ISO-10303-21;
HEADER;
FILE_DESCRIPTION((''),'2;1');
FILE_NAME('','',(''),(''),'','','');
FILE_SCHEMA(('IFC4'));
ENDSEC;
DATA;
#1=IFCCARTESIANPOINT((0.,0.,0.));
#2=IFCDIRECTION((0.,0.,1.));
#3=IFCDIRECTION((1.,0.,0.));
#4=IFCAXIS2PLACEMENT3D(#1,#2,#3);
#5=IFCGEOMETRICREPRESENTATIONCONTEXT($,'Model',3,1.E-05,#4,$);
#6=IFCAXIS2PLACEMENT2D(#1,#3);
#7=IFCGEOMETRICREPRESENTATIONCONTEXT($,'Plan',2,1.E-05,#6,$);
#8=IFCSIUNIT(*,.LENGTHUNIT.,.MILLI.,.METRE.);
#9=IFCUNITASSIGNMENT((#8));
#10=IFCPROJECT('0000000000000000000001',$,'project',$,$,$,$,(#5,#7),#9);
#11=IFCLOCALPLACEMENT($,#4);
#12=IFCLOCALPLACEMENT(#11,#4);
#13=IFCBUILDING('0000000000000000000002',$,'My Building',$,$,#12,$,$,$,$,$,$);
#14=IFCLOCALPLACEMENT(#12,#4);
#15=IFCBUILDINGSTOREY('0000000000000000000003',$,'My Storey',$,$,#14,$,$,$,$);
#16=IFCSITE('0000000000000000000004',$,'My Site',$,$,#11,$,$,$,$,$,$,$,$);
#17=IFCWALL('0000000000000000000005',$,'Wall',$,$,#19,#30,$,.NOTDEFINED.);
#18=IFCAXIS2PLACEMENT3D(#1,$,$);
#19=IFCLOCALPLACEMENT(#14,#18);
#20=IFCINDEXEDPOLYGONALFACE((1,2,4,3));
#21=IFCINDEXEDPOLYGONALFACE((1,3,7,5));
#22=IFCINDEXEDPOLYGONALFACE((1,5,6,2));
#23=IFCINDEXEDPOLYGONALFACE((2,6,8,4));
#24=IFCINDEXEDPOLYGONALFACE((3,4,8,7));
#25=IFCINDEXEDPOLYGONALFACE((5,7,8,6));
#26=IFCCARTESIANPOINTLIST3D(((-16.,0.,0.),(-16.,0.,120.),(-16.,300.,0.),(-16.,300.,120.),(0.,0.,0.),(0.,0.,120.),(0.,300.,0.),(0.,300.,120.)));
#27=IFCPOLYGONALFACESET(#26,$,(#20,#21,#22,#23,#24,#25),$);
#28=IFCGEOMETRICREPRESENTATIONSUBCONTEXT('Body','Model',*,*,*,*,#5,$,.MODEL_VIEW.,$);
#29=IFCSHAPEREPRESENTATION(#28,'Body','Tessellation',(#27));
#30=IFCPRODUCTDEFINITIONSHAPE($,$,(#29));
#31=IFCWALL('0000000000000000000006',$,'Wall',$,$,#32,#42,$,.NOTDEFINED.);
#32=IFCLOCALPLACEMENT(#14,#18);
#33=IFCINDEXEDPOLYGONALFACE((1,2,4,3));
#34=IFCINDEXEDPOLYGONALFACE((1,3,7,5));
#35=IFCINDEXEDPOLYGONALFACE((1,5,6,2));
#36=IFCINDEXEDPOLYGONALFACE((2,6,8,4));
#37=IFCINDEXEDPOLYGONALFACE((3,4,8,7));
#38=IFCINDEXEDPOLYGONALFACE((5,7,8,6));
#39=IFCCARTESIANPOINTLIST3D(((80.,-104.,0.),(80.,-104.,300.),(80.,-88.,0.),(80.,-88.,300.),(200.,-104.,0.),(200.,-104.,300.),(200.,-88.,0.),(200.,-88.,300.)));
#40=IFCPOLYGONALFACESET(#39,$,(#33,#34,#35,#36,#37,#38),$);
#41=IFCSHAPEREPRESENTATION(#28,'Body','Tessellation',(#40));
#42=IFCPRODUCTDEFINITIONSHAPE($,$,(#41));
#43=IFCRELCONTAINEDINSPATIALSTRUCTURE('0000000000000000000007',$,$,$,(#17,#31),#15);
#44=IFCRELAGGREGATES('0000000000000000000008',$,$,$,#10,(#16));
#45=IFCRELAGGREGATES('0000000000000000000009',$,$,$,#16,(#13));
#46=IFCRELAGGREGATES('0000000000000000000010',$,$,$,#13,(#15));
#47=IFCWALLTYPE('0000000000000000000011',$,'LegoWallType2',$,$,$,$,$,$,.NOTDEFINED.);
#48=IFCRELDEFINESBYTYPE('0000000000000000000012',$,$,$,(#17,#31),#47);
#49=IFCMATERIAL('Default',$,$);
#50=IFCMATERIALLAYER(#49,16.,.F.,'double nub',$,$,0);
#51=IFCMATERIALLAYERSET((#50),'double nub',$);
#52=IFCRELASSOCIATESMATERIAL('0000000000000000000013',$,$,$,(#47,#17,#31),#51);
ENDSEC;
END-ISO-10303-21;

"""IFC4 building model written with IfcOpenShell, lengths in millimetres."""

from ifc_helpers import new_model, si_unit, frame, frame_2d, origin_with_axes, place, context, subcontext, project, spatial, indexed_curve, outline, extrude, material, layer, layer_set, layer_usage, type_object, element, save


model = new_model("IFC4")

# Units and contexts
model_context = context("Model", 3, precision=1e-05, world=origin_with_axes())
plan_context = context("Plan", 2, precision=1e-05, world=frame_2d((0.0, 0.0, 0.0), x_axis=(1.0, 0.0, 0.0)))
body_context = subcontext(model_context, "Body", "Model", "MODEL_VIEW")
ifc_project = project(units=[si_unit("LENGTHUNIT", "METRE", prefix="MILLI")], contexts=[model_context, plan_context])

# Site, building, storey
site_placement = place(None, origin_with_axes())
site = spatial("IfcSite", under=ifc_project, at=site_placement, Name="My Site")
building_placement = place(site_placement, origin_with_axes())
building = spatial("IfcBuilding", under=site, at=building_placement, Name="My Building")
storey_placement = place(building_placement, origin_with_axes())
storey = spatial("IfcBuildingStorey", under=building, at=storey_placement, Name="My Storey")

# Walls
ifc_material = material(Name="Default")
ifc_layer = layer(ifc_material, 16.0, ventilated=False, Name="double nub", Priority=0)
ifc_layer_set = layer_set([ifc_layer], Name="double nub")
ifc_layer_usage_1 = layer_usage(ifc_layer_set, "AXIS2", "POSITIVE", 0.0)
wall_type = type_object("IfcWallType", Name="LegoWallType2", PredefinedType="NOTDEFINED", material=ifc_layer_set)
wall_1_placement = place(storey_placement, frame((0.0, 0.0, 0.0), z_axis=(0.0, 0.0, 1.0), x_axis=(0.0, 1.0, 0.0)))
element("IfcWall", 1, at=wall_1_placement, inside=storey, type_object=wall_type, material=ifc_layer_usage_1, Name="Wall", PredefinedType="NOTDEFINED", context=body_context, shape_type="SweptSolid", body=[
    extrude(outline(indexed_curve([(0.0, 0.0), (0.0, 16.0), (300.0, 16.0), (300.0, 0.0), (0.0, 0.0)], self_intersect=False)), origin_with_axes(), (0.0, 0.0, 1.0), 120.0),
])
ifc_layer_usage_2 = layer_usage(ifc_layer_set, "AXIS2", "POSITIVE", 0.0)
wall_2_placement = place(storey_placement, frame((80.0, -104.0, 0.0), z_axis=(0.0, 0.0, 1.0), x_axis=(1.0, 0.0, 0.0)))
element("IfcWall", 2, at=wall_2_placement, inside=storey, type_object=wall_type, material=ifc_layer_usage_2, Name="Wall", PredefinedType="NOTDEFINED", context=body_context, shape_type="SweptSolid", body=[
    extrude(outline(indexed_curve([(0.0, 0.0), (0.0, 16.0), (120.0, 16.0), (120.0, 0.0), (0.0, 0.0)], self_intersect=False)), origin_with_axes(), (0.0, 0.0, 1.0), 300.0),
])

save(model, "model.ifc")
